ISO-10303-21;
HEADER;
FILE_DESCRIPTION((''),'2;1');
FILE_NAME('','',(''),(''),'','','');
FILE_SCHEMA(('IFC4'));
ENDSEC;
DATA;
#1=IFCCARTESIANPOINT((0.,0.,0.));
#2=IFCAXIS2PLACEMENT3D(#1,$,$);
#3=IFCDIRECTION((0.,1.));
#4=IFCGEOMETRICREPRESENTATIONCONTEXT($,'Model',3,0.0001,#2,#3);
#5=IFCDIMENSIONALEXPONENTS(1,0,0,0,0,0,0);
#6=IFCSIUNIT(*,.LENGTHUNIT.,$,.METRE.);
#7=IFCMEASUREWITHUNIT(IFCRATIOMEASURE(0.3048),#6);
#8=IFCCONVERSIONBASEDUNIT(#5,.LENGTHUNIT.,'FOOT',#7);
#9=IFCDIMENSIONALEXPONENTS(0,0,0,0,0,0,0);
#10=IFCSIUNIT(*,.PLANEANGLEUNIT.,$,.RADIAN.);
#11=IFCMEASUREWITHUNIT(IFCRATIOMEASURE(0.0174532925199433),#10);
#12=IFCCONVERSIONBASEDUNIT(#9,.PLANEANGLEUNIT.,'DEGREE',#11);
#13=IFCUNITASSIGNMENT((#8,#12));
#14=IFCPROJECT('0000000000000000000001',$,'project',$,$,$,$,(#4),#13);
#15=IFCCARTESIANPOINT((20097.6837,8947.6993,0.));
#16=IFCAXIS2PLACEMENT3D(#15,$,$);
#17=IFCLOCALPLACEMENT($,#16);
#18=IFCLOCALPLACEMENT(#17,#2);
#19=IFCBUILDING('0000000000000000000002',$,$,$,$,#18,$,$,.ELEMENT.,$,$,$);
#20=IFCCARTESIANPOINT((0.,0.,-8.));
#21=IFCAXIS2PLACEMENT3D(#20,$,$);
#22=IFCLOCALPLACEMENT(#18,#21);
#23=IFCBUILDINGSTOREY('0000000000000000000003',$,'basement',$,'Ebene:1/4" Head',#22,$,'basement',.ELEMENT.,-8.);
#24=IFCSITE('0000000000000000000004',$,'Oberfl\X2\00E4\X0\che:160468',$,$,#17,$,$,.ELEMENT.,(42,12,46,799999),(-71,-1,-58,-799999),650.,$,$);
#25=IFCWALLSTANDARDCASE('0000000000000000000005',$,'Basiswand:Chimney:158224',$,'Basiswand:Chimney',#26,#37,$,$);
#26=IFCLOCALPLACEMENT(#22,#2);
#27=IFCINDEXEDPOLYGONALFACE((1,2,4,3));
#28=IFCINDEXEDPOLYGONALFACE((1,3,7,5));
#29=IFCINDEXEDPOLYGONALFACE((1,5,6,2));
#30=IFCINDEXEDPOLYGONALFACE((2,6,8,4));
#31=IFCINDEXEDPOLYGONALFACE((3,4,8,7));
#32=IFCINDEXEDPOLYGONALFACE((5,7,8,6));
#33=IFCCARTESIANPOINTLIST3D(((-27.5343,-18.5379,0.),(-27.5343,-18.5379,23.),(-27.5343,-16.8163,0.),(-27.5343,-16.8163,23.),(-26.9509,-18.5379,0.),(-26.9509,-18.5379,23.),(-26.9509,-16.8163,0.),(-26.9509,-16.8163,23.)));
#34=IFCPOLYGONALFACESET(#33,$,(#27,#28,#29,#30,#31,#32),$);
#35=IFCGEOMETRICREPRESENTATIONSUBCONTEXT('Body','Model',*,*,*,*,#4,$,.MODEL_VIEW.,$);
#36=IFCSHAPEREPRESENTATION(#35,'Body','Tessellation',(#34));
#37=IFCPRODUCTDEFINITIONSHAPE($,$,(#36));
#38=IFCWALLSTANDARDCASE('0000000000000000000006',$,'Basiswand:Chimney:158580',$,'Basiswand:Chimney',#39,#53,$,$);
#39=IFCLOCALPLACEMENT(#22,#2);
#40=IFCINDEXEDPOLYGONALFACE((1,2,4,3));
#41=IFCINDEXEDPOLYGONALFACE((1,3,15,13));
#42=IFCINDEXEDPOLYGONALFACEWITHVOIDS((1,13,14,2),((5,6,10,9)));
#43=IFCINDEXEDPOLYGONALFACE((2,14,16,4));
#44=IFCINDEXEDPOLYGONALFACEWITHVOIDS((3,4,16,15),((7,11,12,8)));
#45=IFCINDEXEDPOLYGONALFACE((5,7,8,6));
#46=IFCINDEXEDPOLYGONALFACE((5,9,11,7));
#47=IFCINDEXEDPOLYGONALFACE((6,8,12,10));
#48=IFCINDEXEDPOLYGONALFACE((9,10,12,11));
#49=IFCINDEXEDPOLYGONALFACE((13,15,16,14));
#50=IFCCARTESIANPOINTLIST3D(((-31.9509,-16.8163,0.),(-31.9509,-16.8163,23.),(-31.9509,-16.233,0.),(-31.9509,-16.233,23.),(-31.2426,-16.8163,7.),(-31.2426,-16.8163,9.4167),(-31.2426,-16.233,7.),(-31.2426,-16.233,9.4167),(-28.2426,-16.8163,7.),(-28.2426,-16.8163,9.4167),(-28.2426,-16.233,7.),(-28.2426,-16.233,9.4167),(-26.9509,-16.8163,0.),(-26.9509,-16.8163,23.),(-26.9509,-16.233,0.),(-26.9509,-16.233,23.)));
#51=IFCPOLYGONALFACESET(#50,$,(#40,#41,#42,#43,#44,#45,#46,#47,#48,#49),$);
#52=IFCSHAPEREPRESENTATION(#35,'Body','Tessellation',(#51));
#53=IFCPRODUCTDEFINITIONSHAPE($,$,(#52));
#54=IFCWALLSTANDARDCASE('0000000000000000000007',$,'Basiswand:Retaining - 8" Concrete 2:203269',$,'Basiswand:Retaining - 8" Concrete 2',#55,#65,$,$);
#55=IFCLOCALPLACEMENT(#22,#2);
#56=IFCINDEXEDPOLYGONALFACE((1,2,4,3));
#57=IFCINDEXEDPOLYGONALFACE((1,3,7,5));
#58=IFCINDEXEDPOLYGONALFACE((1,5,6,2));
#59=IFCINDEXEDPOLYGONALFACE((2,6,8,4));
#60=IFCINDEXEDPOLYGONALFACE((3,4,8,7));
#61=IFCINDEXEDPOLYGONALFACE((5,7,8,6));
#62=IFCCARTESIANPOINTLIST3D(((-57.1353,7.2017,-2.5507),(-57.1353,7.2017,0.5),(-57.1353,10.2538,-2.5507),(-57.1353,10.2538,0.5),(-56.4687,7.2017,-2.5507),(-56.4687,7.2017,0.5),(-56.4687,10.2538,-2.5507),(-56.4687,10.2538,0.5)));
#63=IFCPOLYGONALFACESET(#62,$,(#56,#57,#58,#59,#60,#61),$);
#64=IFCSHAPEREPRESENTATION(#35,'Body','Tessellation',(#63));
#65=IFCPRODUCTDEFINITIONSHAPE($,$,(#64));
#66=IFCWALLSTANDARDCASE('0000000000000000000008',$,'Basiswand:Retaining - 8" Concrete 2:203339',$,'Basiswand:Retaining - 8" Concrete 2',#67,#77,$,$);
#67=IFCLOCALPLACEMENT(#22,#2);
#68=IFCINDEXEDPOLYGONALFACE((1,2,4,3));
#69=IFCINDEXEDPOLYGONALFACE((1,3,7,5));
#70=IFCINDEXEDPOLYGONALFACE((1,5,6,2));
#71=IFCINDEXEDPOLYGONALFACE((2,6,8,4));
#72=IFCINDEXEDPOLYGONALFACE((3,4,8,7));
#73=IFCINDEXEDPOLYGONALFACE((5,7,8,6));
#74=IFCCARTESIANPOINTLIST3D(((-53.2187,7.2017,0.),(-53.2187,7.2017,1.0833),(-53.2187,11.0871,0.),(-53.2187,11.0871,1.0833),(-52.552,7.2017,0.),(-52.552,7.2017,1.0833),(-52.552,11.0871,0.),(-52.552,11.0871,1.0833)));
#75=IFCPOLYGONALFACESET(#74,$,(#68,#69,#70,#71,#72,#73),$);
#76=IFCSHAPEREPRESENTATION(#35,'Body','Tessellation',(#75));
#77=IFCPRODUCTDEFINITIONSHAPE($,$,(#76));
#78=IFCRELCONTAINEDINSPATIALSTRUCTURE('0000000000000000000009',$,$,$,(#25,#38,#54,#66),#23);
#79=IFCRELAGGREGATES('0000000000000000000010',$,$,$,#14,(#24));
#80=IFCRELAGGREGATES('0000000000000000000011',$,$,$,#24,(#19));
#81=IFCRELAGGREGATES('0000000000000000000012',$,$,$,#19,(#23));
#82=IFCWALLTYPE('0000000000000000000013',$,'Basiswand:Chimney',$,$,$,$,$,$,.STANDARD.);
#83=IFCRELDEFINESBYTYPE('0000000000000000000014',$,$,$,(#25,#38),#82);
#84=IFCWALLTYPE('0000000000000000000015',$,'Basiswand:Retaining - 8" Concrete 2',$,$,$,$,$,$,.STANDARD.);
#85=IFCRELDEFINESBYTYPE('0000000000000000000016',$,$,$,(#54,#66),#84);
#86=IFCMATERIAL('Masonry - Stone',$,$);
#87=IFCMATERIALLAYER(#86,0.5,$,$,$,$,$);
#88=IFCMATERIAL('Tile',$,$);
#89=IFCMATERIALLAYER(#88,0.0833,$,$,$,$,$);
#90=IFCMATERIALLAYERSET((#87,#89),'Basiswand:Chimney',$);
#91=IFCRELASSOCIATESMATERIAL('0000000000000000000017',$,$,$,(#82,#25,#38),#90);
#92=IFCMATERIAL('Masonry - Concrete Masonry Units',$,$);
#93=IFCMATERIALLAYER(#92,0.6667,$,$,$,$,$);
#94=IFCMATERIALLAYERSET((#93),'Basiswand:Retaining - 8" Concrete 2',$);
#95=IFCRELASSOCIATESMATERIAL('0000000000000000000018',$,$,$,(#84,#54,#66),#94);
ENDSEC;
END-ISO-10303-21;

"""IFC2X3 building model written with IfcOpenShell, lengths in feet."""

from ifc_helpers import new_model, entity, si_unit, converted_unit, direction, frame, frame_2d, origin, place, context, subcontext, project, spatial, rectangle, extrude, material, layer, layer_set, layer_usage, type_object, element, save


model = new_model("IFC2X3")

# Units and contexts
model_context = context("Model", 3, precision=0.0001, world=origin(), true_north=direction((0.0, 1.0)))
body_context = subcontext(model_context, "Body", "Model", "MODEL_VIEW")
ifc_project = project(units=[converted_unit("LENGTHUNIT", "FOOT", entity("IfcRatioMeasure", 0.3048), si_unit("LENGTHUNIT", "METRE"), dimensions=[1, 0, 0, 0, 0, 0, 0]), converted_unit("PLANEANGLEUNIT", "DEGREE", entity("IfcRatioMeasure", 0.0174532925199433), si_unit("PLANEANGLEUNIT", "RADIAN"), dimensions=[0, 0, 0, 0, 0, 0, 0])], contexts=[model_context])

# Site, building, storey
site_placement = place(None, frame((20097.6837, 8947.6993, 0.0)))
site = spatial("IfcSite", under=ifc_project, at=site_placement, Name="Oberfläche:160468", CompositionType="ELEMENT", RefLatitude=(42, 12, 46, 799999), RefLongitude=(-71, -1, -58, -799999), RefElevation=650.0)
building_placement = place(site_placement, origin())
building = spatial("IfcBuilding", under=site, at=building_placement, CompositionType="ELEMENT")
storey_placement = place(building_placement, frame((0.0, 0.0, -8.0)))
storey = spatial("IfcBuildingStorey", under=building, at=storey_placement, Name="basement", ObjectType="Ebene:1/4\" Head", LongName="basement", CompositionType="ELEMENT", Elevation=-8.0)

# Wall
ifc_material_1 = material(Name="Masonry - Stone")
ifc_layer_1 = layer(ifc_material_1, 0.5)
ifc_material_2 = material(Name="Tile")
ifc_layer_2 = layer(ifc_material_2, 0.0833)
ifc_layer_set_1 = layer_set([ifc_layer_1, ifc_layer_2], Name="Basiswand:Chimney")
wall_type_1 = type_object("IfcWallType", Name="Basiswand:Chimney", PredefinedType="STANDARD", material=ifc_layer_set_1)
ifc_layer_usage_1 = layer_usage(ifc_layer_set_1, "AXIS2", "NEGATIVE", 0.2917)
wall_1_placement = place(storey_placement, frame((-27.2426, -16.8163, 0.0), z_axis=(0.0, 0.0, 1.0), x_axis=(0.0, -1.0, 0.0)))
element("IfcWallStandardCase", 1, at=wall_1_placement, inside=storey, type_object=wall_type_1, material=ifc_layer_usage_1, Name="Basiswand:Chimney:158224", ObjectType="Basiswand:Chimney", context=body_context, shape_type="SweptSolid", body=[
    extrude(rectangle(XDim=1.7216, YDim=0.5833, at=frame_2d((0.8608, 0.0), x_axis=(-1.0, 0.0))), origin(), (0.0, 0.0, 1.0), 23.0),
])

# Wall, opening
ifc_layer_usage_2 = layer_usage(ifc_layer_set_1, "AXIS2", "NEGATIVE", 0.2917)
wall_2_placement = place(storey_placement, frame((-26.9509, -16.5246, 0.0), z_axis=(0.0, 0.0, 1.0), x_axis=(-1.0, 0.0, 0.0)))
wall_2 = element("IfcWallStandardCase", 2, at=wall_2_placement, inside=storey, type_object=wall_type_1, material=ifc_layer_usage_2, Name="Basiswand:Chimney:158580", ObjectType="Basiswand:Chimney", context=body_context, shape_type="SweptSolid", body=[
    extrude(rectangle(XDim=5.0, YDim=0.5833, at=frame_2d((2.5, 0.0), x_axis=(-1.0, 0.0))), origin(), (0.0, 0.0, 1.0), 23.0),
])
opening_1_placement = place(wall_2_placement, origin())
element("IfcOpeningElement", 3, at=opening_1_placement, cuts=wall_2, ObjectType="Opening", context=body_context, shape_type="SweptSolid", body=[
    extrude(rectangle(XDim=2.4167, YDim=3.0, at=frame_2d((0.0, 0.0), x_axis=(0.0, 1.0))), frame((2.7917, -1.2917, 8.2083), z_axis=(0.0, 1.0, 0.0), x_axis=(-1.0, 0.0, 0.0)), (0.0, 0.0, 1.0), 2.0),
])

# Walls
ifc_material_3 = material(Name="Masonry - Concrete Masonry Units")
ifc_layer_3 = layer(ifc_material_3, 0.6667)
ifc_layer_set_2 = layer_set([ifc_layer_3], Name="Basiswand:Retaining - 8\" Concrete 2")
ifc_layer_usage_3 = layer_usage(ifc_layer_set_2, "AXIS2", "NEGATIVE", 0.3333)
wall_type_2 = type_object("IfcWallType", Name="Basiswand:Retaining - 8\" Concrete 2", PredefinedType="STANDARD", material=ifc_layer_set_2)
wall_3_placement = place(storey_placement, frame((-56.802, 7.2017, -2.5507), z_axis=(0.0, 0.0, 1.0), x_axis=(0.0, 1.0, 0.0)))
element("IfcWallStandardCase", 4, at=wall_3_placement, inside=storey, type_object=wall_type_2, material=ifc_layer_usage_3, Name="Basiswand:Retaining - 8\" Concrete 2:203269", ObjectType="Basiswand:Retaining - 8\" Concrete 2", context=body_context, shape_type="SweptSolid", body=[
    extrude(rectangle(XDim=3.0521, YDim=0.6667, at=frame_2d((1.526, 0.0), x_axis=(-1.0, 0.0))), origin(), (0.0, 0.0, 1.0), 3.0507),
])
ifc_layer_usage_4 = layer_usage(ifc_layer_set_2, "AXIS2", "NEGATIVE", 0.3333)
wall_4_placement = place(storey_placement, frame((-52.8853, 7.2017, 0.0), z_axis=(0.0, 0.0, 1.0), x_axis=(0.0, 1.0, 0.0)))
element("IfcWallStandardCase", 5, at=wall_4_placement, inside=storey, type_object=wall_type_2, material=ifc_layer_usage_4, Name="Basiswand:Retaining - 8\" Concrete 2:203339", ObjectType="Basiswand:Retaining - 8\" Concrete 2", context=body_context, shape_type="SweptSolid", body=[
    extrude(rectangle(XDim=3.8854, YDim=0.6667, at=frame_2d((1.9427, 0.0), x_axis=(-1.0, 0.0))), origin(), (0.0, 0.0, 1.0), 1.0833),
])

save(model, "model.ifc")
